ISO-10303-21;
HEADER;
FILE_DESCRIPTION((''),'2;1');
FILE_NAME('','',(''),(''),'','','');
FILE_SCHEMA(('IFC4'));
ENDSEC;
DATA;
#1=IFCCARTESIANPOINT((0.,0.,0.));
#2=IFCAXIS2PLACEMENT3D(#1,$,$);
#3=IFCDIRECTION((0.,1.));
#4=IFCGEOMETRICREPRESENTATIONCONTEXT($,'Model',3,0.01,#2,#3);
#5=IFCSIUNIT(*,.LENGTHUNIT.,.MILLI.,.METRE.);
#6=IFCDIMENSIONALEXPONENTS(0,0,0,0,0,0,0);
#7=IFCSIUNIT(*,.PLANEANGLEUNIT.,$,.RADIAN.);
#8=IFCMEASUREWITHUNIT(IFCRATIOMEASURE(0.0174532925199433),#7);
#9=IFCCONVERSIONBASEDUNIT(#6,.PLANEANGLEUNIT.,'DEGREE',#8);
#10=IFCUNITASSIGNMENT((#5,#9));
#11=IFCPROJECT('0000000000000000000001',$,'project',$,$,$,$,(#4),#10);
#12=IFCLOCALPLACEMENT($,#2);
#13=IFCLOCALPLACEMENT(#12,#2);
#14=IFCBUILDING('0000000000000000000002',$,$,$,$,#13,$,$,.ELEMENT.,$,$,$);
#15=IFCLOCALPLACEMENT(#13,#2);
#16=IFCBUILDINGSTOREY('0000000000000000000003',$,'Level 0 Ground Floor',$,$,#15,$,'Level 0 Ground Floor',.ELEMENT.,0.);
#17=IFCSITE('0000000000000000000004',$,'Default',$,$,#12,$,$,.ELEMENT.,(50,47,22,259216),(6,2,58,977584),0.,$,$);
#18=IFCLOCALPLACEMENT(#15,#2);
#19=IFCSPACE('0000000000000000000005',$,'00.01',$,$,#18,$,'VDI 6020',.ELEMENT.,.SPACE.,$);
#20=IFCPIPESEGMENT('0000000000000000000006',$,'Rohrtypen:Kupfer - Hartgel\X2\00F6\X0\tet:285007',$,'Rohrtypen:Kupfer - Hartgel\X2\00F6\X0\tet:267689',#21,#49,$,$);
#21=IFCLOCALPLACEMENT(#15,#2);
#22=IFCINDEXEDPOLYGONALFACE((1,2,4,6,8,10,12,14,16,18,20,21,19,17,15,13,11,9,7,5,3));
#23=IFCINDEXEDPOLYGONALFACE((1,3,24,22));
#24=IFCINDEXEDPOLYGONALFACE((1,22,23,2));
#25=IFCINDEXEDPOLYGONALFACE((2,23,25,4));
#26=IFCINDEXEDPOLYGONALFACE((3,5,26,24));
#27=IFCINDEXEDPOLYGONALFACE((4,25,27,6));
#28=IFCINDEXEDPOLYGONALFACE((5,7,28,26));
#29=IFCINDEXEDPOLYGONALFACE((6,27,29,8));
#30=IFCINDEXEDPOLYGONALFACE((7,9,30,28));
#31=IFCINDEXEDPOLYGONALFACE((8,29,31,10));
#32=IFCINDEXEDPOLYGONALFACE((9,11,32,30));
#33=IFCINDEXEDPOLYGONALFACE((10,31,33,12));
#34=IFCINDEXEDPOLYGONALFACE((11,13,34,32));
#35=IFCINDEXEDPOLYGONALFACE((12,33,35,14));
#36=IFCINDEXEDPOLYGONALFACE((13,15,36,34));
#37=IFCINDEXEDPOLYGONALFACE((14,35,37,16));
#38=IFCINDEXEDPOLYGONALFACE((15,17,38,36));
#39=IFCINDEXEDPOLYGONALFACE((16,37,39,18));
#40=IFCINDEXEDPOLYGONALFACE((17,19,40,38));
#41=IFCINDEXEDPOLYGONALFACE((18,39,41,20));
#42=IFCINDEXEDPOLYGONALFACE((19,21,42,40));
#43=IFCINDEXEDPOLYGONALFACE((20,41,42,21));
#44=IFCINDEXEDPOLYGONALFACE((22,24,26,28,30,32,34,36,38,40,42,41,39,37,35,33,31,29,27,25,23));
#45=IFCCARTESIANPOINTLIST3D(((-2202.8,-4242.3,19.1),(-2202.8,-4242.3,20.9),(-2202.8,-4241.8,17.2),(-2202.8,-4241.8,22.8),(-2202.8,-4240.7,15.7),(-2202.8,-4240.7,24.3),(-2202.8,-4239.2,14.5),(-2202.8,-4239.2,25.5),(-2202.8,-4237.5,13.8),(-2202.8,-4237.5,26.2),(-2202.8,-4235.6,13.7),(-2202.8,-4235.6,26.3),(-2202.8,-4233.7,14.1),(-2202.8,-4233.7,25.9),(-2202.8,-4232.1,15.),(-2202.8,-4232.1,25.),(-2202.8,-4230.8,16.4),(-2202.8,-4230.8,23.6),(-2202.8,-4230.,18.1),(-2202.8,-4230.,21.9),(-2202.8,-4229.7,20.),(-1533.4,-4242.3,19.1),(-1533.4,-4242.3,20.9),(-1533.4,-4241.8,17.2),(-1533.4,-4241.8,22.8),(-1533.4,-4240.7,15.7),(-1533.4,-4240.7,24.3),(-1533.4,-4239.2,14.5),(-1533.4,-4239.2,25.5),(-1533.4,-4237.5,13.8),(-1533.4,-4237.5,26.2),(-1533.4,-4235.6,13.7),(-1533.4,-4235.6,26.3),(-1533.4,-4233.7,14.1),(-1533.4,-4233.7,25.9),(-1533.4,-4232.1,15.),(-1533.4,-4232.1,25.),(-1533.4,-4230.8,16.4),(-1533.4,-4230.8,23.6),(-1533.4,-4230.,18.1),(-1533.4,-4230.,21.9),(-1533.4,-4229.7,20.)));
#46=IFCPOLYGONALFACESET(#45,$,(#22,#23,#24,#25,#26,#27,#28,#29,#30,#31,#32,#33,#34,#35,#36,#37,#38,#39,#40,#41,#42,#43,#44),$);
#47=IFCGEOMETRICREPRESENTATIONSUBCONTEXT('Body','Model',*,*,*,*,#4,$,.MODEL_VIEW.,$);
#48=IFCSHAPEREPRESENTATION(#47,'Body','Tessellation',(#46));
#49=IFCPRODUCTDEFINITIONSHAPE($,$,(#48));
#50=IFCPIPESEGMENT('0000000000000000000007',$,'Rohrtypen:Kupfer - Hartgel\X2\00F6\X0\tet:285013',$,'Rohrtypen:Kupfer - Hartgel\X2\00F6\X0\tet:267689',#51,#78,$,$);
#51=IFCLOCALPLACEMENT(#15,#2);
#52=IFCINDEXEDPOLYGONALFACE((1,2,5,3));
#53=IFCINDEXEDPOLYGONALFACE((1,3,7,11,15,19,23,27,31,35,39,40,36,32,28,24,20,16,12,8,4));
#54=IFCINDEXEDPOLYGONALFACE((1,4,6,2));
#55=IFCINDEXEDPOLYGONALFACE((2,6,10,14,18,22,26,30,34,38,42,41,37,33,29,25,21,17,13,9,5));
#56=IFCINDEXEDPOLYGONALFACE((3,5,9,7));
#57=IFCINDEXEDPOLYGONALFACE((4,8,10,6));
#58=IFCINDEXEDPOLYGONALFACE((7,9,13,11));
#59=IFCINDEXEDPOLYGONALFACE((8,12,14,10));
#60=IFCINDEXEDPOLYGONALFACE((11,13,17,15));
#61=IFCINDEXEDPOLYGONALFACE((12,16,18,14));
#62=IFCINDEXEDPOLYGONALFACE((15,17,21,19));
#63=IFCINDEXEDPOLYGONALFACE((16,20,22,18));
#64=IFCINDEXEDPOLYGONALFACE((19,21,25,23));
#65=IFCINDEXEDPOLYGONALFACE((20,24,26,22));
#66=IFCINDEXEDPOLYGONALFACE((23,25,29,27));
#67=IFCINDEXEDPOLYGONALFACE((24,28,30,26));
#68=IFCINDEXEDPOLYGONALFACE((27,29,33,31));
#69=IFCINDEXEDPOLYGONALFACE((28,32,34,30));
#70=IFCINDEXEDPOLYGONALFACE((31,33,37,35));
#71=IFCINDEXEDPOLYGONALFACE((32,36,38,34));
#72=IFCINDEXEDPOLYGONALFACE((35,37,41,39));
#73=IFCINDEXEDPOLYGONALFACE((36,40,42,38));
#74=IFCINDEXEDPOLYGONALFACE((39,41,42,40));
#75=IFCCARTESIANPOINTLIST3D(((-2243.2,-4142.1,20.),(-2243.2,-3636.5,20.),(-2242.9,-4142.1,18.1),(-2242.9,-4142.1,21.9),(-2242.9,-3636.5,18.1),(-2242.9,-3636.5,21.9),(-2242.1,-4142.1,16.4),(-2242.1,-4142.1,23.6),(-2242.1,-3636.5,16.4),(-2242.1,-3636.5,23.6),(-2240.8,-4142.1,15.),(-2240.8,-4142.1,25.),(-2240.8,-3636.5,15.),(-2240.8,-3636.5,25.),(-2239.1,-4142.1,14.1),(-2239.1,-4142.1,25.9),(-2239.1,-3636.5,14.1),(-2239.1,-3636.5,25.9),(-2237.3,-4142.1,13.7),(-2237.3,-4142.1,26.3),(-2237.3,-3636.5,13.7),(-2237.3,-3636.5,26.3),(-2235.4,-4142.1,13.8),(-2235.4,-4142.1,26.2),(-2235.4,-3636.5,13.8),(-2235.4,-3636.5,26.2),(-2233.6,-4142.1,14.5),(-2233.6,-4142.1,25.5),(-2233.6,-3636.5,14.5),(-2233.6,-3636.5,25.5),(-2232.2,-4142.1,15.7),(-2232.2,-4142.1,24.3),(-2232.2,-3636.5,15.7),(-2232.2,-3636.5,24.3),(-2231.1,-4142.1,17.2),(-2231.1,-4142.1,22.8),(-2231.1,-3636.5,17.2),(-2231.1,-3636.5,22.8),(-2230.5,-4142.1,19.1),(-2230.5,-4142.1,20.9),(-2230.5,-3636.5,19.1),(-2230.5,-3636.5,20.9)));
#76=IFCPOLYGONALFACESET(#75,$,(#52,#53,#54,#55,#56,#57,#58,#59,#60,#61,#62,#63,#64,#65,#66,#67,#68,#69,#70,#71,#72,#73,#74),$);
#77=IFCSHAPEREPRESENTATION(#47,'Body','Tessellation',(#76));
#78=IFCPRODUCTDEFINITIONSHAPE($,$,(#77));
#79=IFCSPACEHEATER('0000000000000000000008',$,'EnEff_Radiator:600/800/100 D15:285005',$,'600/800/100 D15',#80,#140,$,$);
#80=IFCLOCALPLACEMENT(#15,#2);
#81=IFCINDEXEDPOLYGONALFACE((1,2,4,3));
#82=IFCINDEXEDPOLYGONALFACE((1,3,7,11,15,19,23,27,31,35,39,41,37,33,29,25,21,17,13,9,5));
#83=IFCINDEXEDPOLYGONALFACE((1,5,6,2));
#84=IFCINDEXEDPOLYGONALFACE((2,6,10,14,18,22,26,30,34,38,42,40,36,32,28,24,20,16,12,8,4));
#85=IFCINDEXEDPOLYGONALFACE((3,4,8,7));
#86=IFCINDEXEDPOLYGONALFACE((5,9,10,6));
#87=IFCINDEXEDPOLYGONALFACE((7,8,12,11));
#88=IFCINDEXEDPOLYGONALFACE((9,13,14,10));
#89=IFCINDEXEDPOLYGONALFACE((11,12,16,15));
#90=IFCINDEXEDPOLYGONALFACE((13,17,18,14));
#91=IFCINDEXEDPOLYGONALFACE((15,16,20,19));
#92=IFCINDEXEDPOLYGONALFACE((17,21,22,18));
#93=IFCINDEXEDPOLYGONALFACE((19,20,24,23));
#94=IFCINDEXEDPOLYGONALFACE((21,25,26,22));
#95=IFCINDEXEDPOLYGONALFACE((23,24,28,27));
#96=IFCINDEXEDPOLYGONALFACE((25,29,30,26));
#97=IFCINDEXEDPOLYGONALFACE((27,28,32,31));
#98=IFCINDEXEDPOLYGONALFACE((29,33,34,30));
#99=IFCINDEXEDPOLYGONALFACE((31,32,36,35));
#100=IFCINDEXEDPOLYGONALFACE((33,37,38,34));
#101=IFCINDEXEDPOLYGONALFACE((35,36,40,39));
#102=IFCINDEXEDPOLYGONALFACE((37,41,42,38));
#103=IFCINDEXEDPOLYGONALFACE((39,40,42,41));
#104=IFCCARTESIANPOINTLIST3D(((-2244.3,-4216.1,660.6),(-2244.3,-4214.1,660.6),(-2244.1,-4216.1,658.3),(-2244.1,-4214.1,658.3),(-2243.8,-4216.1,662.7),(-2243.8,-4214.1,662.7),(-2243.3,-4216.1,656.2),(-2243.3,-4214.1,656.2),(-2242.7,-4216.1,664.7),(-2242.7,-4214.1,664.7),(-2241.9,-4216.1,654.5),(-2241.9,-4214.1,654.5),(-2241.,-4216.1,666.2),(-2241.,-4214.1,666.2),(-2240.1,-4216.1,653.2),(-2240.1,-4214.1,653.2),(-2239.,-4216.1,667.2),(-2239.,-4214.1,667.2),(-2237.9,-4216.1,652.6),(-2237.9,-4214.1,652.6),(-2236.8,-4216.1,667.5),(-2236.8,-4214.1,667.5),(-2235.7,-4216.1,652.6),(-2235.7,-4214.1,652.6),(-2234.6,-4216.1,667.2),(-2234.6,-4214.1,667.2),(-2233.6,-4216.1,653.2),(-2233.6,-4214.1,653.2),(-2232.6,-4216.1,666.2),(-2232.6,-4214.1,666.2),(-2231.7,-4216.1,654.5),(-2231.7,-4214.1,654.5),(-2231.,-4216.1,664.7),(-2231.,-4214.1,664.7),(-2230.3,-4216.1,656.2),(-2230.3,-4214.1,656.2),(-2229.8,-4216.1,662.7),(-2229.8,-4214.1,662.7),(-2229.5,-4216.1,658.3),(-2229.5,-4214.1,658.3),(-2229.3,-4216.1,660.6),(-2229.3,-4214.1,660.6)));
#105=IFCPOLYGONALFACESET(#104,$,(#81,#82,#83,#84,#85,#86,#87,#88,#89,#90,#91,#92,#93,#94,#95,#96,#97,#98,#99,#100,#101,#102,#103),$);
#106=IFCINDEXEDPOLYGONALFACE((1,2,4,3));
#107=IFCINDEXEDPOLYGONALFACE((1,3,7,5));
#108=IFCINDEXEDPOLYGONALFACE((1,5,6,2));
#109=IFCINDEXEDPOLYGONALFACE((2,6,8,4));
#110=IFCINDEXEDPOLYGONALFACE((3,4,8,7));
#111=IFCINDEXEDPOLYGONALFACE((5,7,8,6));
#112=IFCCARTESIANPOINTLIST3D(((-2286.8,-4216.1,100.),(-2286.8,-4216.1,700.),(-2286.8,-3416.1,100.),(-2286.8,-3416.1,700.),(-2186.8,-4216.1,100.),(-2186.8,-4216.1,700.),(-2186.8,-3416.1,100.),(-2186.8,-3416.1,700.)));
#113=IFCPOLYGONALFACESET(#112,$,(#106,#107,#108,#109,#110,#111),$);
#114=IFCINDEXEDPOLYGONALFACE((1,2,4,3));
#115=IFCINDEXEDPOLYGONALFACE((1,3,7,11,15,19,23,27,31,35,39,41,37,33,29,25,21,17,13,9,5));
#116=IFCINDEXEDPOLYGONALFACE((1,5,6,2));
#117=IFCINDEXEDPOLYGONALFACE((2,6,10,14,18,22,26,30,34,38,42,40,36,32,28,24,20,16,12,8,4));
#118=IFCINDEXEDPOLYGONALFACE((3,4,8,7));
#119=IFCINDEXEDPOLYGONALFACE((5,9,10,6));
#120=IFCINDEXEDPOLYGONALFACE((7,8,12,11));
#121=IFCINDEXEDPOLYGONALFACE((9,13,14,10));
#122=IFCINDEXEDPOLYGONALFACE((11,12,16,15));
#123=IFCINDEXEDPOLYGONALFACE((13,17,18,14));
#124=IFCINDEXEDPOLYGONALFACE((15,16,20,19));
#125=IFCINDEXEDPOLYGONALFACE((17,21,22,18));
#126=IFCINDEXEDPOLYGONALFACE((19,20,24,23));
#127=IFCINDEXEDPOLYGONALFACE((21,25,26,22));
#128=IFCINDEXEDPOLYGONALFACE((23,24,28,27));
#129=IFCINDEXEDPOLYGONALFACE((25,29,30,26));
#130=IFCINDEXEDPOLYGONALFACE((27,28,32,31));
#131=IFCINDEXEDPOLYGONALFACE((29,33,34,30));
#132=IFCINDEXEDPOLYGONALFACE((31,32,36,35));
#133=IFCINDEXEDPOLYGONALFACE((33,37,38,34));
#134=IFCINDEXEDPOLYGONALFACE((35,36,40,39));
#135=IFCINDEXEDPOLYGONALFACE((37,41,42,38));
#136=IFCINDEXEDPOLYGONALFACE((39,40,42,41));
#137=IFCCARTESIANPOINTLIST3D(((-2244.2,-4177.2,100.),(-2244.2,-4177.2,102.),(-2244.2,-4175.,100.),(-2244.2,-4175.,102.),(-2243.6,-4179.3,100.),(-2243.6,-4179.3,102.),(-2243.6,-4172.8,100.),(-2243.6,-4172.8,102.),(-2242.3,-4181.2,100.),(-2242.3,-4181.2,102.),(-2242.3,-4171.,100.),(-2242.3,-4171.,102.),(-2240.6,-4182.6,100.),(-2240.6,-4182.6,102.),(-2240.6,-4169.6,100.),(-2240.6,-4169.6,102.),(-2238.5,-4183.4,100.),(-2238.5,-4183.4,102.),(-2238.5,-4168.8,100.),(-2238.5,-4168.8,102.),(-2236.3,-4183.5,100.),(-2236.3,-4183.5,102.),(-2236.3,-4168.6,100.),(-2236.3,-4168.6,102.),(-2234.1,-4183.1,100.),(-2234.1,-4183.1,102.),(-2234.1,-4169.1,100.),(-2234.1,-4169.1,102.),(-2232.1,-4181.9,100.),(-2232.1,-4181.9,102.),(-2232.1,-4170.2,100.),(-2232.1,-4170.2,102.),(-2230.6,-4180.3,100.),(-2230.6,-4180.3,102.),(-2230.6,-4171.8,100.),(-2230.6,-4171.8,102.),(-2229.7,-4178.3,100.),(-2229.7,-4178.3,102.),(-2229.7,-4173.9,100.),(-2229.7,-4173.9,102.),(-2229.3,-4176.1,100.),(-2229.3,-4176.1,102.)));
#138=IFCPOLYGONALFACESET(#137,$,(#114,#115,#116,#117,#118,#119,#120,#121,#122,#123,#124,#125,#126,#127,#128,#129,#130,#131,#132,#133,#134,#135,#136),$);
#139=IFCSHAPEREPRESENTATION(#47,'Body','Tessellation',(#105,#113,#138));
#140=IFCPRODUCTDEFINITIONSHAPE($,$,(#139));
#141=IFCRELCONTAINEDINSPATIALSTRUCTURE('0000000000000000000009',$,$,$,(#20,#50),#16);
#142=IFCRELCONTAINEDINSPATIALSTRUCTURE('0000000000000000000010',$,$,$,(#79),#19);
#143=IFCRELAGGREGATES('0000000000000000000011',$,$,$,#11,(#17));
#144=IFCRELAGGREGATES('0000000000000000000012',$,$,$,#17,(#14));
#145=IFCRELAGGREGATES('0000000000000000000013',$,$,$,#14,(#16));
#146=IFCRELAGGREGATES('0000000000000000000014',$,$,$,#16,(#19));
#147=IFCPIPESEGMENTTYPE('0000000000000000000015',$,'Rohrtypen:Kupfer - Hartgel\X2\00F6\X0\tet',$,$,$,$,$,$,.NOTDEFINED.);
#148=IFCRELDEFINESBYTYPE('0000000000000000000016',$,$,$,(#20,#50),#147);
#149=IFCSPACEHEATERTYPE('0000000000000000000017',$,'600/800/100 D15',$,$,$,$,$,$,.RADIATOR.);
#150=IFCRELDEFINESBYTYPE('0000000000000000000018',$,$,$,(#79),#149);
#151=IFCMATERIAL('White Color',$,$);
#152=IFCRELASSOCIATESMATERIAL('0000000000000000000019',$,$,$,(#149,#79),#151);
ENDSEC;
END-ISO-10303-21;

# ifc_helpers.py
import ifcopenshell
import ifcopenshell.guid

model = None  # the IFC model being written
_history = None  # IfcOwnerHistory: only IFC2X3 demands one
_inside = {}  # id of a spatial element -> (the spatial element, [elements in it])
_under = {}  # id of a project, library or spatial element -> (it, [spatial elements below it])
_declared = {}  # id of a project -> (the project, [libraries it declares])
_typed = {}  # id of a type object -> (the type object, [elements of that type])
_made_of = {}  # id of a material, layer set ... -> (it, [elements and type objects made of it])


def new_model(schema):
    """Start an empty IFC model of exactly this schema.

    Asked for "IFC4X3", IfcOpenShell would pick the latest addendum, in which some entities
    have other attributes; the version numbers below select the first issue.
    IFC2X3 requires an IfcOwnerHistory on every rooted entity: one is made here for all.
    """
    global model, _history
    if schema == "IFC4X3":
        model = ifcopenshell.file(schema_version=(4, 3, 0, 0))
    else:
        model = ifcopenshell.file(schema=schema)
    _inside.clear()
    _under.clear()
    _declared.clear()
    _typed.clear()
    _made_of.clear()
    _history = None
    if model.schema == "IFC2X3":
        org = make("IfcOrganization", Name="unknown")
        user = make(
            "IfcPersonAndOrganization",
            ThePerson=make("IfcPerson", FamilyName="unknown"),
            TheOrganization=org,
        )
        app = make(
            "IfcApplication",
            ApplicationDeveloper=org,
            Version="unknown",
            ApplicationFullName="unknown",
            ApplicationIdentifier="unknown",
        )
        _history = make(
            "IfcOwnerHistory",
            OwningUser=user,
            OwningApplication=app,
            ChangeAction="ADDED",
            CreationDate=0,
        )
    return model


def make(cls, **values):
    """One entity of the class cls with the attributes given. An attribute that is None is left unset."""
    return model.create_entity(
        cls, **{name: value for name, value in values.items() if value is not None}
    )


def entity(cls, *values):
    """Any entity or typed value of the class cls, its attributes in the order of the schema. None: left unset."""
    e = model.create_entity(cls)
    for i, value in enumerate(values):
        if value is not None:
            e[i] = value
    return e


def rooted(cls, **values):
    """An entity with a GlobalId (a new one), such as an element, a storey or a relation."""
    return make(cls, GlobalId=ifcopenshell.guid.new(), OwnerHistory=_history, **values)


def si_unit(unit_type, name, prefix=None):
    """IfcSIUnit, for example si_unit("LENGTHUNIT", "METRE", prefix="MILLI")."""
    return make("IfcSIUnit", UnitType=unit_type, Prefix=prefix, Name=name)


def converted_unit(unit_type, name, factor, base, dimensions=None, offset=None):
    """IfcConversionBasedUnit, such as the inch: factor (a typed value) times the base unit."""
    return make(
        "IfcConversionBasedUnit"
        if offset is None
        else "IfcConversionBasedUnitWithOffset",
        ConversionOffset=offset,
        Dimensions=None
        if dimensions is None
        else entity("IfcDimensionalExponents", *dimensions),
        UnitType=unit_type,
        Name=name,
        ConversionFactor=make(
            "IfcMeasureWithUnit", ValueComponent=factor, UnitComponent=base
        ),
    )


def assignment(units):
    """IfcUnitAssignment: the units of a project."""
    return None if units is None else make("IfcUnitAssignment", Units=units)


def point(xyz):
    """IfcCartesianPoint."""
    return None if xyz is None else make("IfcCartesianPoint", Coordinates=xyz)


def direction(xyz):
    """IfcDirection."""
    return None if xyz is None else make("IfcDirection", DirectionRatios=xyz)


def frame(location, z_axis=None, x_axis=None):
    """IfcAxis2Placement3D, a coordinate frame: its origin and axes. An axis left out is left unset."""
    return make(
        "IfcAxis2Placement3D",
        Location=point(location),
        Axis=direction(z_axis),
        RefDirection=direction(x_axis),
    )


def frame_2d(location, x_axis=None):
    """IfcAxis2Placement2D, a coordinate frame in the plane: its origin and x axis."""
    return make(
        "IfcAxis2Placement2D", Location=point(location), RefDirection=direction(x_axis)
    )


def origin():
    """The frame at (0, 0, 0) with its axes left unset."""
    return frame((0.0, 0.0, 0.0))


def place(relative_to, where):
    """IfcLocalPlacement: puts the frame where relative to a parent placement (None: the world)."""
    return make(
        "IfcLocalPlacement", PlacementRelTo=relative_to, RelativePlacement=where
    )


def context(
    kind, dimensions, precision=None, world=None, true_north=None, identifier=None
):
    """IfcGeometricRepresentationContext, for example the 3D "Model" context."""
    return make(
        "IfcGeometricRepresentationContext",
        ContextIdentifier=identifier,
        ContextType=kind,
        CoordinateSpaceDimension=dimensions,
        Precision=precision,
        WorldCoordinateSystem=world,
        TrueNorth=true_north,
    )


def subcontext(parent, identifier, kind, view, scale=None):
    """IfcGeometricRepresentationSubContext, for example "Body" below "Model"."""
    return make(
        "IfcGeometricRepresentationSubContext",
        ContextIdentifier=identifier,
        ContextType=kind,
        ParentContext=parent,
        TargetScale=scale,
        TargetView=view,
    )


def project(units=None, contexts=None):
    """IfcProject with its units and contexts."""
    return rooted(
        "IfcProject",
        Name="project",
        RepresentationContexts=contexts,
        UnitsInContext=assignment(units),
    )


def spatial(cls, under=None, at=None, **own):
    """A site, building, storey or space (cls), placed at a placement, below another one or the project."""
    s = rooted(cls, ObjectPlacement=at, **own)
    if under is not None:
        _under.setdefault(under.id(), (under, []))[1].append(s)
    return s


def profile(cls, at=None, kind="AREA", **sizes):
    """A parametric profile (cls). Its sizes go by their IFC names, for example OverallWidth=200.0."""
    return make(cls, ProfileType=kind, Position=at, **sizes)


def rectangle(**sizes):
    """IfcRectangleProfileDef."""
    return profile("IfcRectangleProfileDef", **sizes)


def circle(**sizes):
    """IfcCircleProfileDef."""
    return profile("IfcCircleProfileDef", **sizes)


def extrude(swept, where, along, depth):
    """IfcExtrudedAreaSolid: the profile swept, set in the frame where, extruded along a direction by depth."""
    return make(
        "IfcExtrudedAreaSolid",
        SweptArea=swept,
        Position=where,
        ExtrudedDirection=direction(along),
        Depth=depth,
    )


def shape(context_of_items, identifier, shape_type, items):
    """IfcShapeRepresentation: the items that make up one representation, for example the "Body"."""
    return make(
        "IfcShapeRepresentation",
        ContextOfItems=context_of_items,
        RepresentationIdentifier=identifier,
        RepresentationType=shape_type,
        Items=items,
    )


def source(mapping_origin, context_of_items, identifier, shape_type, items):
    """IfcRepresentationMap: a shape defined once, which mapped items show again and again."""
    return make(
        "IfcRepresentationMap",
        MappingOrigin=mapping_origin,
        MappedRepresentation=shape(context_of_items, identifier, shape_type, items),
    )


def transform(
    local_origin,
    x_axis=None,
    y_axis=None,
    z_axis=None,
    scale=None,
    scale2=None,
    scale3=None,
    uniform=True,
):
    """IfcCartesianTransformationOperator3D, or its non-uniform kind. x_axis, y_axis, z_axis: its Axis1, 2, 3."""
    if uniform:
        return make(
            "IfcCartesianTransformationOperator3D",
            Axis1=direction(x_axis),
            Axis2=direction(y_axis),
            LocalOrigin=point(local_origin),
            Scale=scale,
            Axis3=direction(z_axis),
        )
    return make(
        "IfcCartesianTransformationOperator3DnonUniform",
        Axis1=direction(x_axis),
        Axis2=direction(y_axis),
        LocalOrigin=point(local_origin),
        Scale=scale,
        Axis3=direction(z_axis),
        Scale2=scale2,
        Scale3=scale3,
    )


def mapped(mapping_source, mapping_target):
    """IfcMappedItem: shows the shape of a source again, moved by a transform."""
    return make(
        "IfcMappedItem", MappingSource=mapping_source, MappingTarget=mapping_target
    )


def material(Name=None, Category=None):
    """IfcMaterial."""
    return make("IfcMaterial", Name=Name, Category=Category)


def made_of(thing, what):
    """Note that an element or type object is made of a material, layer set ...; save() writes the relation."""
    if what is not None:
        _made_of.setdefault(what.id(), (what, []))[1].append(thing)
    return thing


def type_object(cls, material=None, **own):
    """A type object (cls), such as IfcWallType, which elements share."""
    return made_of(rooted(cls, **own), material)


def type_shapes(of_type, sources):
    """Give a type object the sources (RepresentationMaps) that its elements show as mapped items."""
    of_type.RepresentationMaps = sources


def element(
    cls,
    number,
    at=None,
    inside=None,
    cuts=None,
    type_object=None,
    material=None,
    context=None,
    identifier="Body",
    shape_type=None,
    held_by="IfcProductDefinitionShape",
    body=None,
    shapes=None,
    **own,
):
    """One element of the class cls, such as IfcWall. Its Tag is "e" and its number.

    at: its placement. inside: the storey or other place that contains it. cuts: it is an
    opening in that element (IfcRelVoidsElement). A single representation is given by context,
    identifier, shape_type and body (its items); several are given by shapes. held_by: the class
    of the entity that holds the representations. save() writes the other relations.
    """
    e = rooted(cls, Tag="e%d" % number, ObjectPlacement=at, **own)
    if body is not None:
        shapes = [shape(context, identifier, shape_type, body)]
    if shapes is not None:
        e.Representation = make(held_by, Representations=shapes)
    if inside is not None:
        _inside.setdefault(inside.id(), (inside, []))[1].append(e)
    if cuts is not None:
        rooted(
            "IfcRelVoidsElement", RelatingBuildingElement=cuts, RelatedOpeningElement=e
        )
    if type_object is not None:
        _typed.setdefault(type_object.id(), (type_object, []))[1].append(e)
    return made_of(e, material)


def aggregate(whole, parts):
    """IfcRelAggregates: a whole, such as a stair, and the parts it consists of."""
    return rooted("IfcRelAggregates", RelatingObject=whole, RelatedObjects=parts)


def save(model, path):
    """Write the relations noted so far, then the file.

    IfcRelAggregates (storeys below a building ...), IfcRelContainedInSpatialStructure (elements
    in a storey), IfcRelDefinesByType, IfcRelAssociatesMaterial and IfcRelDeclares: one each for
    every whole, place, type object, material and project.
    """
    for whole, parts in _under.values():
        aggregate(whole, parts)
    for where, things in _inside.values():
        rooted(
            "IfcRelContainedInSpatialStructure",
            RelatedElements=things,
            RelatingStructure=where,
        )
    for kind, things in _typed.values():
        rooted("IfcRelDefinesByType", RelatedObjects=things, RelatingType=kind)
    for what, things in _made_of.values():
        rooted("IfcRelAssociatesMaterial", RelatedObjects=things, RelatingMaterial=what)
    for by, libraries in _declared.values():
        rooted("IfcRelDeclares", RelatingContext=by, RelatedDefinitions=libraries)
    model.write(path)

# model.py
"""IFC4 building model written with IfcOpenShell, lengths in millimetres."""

from ifc_helpers import new_model, entity, si_unit, converted_unit, direction, frame, frame_2d, origin, place, context, subcontext, project, spatial, rectangle, circle, extrude, source, transform, mapped, material, type_object, type_shapes, element, save


model = new_model("IFC4")

# Units and contexts
model_context = context("Model", 3, precision=0.01, world=origin(), true_north=direction((0.0, 1.0)))
body_context = subcontext(model_context, "Body", "Model", "MODEL_VIEW")
ifc_project = project(units=[si_unit("LENGTHUNIT", "METRE", prefix="MILLI"), converted_unit("PLANEANGLEUNIT", "DEGREE", entity("IfcRatioMeasure", 0.0174532925199433), si_unit("PLANEANGLEUNIT", "RADIAN"), dimensions=[0, 0, 0, 0, 0, 0, 0])], contexts=[model_context])

# Site, building, storey
site_placement = place(None, origin())
site = spatial("IfcSite", under=ifc_project, at=site_placement, Name="Default", CompositionType="ELEMENT", RefLatitude=(50, 47, 22, 259216), RefLongitude=(6, 2, 58, 977584), RefElevation=0.0)
building_placement = place(site_placement, origin())
building = spatial("IfcBuilding", under=site, at=building_placement, CompositionType="ELEMENT")
storey_placement = place(building_placement, origin())
storey = spatial("IfcBuildingStorey", under=building, at=storey_placement, Name="Level 0 Ground Floor", LongName="Level 0 Ground Floor", CompositionType="ELEMENT", Elevation=0.0)

# Pipe segments
pipe_segment_type = type_object("IfcPipeSegmentType", Name="Rohrtypen:Kupfer - Hartgelötet", PredefinedType="NOTDEFINED")
pipe_segment_1_placement = place(storey_placement, frame((-2202.8, -4244.0, 12.1)))
element("IfcPipeSegment", 1, at=pipe_segment_1_placement, inside=storey, type_object=pipe_segment_type, Name="Rohrtypen:Kupfer - Hartgelötet:285007", ObjectType="Rohrtypen:Kupfer - Hartgelötet:267689", context=body_context, shape_type="SweptSolid", body=[
    extrude(circle(Radius=6.3, at=frame_2d((0.0, 0.0), x_axis=(1.0, 0.0))), frame((0.0, 7.9, 7.9), z_axis=(1.0, 0.000044, 0.0), x_axis=(-0.000044, 1.0, 0.0)), (0.0, 0.0, 1.0), 669.4),
])
pipe_segment_2_placement = place(storey_placement, frame((-2244.8, -4142.1, 12.1)))
element("IfcPipeSegment", 2, at=pipe_segment_2_placement, inside=storey, type_object=pipe_segment_type, Name="Rohrtypen:Kupfer - Hartgelötet:285013", ObjectType="Rohrtypen:Kupfer - Hartgelötet:267689", context=body_context, shape_type="SweptSolid", body=[
    extrude(circle(Radius=6.3, at=frame_2d((0.0, 0.0), x_axis=(1.0, 0.0))), frame((7.9, 0.0, 7.9), z_axis=(0.0, 1.0, 0.0), x_axis=(-1.0, 0.0, 0.0)), (0.0, 0.0, 1.0), 505.5),
])

# Shared definitions
space_placement = place(storey_placement, origin())
space = spatial("IfcSpace", under=storey, at=space_placement, Name="00.01", LongName="VDI 6020", CompositionType="ELEMENT", PredefinedType="SPACE")

# Space heater
ifc_material_1 = material(Name="White Color")
space_heater_type = type_object("IfcSpaceHeaterType", Name="600/800/100 D15", PredefinedType="RADIATOR", material=ifc_material_1)
shared_shape_1 = source(origin(), body_context, "Body", "SweptSolid", [
    extrude(circle(Radius=7.5, at=frame_2d((0.0, 0.0), x_axis=(1.0, 0.0))), frame((798.0, 50.0, 560.0), z_axis=(1.0, 0.0, 0.0), x_axis=(0.0, 0.0, 1.0)), (0.0, 0.0, 1.0), 2.0),
    extrude(rectangle(XDim=100.0, YDim=800.0, at=frame_2d((0.0, 0.0), x_axis=(1.0, 0.0))), frame((400.0, 50.0, 0.0), z_axis=(0.0, 0.0, 1.0), x_axis=(0.0, 1.0, 0.0)), (0.0, 0.0, 1.0), 600.0),
    extrude(circle(Radius=7.5, at=frame_2d((0.0, 0.0), x_axis=(1.0, 0.0))), frame((760.0, 50.0, 0.0), z_axis=(0.0, 0.0, 1.0), x_axis=(0.0, 1.0, 0.0)), (0.0, 0.0, 1.0), 2.0),
])
type_shapes(space_heater_type, [shared_shape_1])
space_heater_placement = place(space_placement, frame((-2286.8, -3416.1, 100.0), z_axis=(0.0, 0.0, 1.0), x_axis=(0.0, -1.0, 0.0)))
element("IfcSpaceHeater", 3, at=space_heater_placement, inside=space, type_object=space_heater_type, material=ifc_material_1, Name="EnEff_Radiator:600/800/100 D15:285005", ObjectType="600/800/100 D15", context=body_context, shape_type="MappedRepresentation", body=[
    mapped(shared_shape_1, transform((0.0, 0.0, 0.0), scale=1.0)),
])

save(model, "model.ifc")
